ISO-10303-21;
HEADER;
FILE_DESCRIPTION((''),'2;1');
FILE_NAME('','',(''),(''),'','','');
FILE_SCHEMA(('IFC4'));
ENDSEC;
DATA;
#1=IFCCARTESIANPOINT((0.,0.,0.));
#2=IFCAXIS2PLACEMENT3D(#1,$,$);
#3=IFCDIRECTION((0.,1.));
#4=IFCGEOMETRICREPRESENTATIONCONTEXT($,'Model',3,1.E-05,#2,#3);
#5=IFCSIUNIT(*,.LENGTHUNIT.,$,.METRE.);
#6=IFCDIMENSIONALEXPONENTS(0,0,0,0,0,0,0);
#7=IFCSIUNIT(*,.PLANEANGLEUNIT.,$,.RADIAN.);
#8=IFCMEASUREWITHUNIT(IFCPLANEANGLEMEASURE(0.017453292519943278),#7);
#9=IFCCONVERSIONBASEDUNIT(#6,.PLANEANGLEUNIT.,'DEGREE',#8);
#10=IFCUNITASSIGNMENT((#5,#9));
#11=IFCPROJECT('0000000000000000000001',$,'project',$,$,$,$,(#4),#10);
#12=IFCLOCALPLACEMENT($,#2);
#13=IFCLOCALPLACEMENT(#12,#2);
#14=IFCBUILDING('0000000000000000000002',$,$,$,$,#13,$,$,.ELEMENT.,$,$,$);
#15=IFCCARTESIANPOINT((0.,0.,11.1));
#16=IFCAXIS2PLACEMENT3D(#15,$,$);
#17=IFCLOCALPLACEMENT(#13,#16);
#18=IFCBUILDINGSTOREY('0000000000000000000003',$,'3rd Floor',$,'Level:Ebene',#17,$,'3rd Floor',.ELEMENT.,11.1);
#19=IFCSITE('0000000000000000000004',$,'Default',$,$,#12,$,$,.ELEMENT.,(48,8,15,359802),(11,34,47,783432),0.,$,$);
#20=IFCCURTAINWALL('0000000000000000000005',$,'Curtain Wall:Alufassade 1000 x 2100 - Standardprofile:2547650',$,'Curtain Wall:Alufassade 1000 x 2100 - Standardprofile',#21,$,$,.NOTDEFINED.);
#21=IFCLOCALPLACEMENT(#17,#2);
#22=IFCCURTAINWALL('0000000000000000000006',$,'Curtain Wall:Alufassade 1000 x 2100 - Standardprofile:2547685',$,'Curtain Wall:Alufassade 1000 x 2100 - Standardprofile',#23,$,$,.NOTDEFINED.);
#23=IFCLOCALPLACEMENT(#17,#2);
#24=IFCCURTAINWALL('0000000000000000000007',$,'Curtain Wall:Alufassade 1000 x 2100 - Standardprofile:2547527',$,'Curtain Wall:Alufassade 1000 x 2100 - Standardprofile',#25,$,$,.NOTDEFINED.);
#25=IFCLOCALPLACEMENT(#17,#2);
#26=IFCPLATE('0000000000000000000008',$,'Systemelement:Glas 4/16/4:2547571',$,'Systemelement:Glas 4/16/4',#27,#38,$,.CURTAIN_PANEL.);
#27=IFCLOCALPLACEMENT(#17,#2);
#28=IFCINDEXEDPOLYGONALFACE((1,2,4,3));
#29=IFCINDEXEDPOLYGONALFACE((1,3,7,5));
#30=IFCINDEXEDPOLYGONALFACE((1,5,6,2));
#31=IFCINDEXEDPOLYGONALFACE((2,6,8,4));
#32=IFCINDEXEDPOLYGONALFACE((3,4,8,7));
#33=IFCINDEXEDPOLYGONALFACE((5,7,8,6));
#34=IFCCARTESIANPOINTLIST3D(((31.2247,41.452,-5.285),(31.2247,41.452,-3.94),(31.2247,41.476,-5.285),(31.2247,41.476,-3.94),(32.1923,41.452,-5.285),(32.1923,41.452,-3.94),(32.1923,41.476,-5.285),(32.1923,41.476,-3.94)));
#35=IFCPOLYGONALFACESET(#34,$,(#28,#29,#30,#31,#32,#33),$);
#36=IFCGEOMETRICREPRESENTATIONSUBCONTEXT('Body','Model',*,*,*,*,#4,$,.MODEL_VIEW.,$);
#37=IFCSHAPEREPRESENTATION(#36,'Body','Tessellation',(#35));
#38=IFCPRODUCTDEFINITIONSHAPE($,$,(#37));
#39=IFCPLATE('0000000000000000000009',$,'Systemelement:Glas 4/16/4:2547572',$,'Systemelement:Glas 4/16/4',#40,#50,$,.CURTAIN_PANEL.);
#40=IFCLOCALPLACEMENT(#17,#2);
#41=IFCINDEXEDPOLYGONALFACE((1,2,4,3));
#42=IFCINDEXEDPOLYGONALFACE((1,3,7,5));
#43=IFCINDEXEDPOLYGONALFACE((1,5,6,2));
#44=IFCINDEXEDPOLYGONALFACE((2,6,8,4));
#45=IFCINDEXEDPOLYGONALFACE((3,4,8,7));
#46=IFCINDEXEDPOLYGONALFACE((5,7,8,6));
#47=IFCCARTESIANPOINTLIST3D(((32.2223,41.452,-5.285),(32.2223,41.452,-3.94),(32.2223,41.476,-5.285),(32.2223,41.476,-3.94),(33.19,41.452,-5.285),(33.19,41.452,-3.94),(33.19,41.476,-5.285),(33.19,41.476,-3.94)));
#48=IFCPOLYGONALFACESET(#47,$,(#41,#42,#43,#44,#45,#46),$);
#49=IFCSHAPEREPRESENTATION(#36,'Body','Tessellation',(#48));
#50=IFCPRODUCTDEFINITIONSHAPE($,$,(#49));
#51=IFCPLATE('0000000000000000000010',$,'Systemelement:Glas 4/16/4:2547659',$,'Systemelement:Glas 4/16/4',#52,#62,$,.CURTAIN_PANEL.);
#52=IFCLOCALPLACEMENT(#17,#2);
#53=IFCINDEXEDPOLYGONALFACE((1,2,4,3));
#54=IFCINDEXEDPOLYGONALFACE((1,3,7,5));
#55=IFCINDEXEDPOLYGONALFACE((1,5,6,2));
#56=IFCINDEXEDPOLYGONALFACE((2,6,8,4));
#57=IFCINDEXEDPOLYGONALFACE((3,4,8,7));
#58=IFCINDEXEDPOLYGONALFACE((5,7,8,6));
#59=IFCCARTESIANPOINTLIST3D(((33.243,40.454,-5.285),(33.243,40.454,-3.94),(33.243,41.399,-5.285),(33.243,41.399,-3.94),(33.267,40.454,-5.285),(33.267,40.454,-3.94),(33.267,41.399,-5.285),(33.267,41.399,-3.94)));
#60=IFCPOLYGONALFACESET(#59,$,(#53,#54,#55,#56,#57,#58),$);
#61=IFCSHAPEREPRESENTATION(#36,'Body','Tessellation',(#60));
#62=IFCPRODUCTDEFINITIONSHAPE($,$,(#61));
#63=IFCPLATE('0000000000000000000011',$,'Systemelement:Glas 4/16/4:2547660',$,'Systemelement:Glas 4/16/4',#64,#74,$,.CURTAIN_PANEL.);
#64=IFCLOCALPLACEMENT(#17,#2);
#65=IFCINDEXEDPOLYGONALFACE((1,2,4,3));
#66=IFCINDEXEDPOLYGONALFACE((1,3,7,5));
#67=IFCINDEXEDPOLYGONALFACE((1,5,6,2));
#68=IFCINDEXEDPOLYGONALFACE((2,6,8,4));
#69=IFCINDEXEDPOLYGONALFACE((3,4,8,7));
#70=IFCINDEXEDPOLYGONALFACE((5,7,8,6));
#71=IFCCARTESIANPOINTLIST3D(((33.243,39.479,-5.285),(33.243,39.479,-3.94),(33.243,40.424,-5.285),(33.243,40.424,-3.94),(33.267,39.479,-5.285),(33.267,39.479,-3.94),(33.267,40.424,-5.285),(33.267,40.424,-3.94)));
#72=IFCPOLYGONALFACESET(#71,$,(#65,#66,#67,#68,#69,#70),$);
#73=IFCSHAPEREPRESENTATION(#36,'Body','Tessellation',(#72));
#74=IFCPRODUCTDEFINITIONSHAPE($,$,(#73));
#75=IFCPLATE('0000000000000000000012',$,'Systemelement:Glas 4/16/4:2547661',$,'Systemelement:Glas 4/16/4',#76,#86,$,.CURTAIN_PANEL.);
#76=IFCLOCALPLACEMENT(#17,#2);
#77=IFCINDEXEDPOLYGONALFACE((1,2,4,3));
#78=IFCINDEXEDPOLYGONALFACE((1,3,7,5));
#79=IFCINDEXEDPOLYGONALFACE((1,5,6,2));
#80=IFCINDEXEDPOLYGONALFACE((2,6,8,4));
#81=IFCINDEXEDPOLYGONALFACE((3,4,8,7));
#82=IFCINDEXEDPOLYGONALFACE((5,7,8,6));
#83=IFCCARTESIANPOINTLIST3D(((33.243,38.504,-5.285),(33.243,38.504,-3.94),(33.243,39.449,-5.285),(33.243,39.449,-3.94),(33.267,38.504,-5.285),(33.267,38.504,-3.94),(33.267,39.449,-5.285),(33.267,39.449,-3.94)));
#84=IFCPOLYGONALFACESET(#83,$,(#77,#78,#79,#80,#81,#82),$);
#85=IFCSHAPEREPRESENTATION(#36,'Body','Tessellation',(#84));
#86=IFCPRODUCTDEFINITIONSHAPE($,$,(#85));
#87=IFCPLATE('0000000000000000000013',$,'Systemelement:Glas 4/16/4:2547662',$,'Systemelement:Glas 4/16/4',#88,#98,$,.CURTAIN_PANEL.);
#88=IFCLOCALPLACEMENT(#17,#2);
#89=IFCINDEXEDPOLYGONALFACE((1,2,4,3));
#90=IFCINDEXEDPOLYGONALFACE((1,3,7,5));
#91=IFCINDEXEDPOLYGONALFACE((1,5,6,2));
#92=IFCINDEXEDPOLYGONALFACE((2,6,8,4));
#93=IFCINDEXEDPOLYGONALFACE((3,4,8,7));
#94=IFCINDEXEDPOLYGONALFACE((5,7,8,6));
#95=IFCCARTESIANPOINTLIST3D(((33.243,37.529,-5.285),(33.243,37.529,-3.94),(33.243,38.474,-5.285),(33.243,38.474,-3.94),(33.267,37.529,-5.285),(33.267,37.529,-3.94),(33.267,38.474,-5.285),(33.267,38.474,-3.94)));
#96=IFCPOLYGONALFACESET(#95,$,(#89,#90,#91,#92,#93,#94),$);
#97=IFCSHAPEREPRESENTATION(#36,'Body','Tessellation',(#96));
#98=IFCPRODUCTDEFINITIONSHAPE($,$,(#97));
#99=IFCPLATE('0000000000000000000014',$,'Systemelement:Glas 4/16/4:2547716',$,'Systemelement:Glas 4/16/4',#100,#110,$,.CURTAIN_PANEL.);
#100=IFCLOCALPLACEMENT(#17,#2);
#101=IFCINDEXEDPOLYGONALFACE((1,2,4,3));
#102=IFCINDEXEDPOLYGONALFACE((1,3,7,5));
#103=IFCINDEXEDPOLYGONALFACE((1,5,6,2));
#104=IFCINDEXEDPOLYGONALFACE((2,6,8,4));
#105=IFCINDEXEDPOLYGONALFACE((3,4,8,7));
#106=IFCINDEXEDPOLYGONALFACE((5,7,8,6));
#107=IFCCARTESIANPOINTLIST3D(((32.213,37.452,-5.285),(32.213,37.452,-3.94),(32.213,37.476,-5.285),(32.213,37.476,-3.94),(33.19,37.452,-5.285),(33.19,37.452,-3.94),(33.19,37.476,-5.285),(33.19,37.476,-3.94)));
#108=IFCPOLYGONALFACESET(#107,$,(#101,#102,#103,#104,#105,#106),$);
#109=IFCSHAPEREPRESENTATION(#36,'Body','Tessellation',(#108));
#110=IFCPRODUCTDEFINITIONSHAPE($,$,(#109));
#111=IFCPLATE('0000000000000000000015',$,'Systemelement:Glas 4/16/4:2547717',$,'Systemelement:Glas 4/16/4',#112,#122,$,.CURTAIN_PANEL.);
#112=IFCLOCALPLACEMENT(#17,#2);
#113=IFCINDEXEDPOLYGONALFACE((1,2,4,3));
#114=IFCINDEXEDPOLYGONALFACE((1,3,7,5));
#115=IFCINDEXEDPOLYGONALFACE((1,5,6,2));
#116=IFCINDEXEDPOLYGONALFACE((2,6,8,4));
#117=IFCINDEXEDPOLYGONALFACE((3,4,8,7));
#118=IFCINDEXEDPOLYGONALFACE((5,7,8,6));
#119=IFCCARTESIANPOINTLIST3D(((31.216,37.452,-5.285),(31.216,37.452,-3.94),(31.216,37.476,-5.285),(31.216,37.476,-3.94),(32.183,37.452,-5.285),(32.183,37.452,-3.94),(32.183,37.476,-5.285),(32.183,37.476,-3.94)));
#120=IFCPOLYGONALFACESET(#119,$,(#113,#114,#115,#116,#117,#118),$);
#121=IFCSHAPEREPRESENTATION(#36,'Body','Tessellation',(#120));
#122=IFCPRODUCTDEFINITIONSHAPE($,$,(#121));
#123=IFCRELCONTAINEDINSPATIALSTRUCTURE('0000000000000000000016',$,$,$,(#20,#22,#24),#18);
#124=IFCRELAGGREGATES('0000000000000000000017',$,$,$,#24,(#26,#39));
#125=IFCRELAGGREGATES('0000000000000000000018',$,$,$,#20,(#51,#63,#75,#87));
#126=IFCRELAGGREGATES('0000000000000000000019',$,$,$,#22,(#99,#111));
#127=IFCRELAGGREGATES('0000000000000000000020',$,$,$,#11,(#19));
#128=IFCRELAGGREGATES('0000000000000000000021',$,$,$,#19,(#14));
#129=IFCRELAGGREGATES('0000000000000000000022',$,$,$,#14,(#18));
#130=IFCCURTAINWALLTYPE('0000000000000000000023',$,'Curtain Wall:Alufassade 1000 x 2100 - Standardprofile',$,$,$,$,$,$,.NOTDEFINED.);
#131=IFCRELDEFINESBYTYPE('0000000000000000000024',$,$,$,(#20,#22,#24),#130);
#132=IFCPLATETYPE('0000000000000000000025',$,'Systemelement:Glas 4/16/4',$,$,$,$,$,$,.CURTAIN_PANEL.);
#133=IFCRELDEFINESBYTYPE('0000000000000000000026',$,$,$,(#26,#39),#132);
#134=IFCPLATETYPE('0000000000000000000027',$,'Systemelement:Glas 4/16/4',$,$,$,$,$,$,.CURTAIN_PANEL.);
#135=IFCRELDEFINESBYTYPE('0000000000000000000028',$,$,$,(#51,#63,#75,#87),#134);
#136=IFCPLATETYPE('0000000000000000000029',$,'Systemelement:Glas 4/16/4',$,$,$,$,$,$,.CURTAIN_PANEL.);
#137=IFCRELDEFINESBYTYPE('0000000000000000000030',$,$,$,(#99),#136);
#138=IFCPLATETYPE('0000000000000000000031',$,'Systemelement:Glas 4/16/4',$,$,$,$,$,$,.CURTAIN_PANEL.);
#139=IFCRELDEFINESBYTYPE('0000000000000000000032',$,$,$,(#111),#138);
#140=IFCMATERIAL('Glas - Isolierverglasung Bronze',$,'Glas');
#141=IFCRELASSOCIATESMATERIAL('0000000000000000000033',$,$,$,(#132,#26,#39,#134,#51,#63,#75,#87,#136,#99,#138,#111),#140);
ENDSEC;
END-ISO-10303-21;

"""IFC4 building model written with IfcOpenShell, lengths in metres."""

from ifc_helpers import new_model, entity, si_unit, converted_unit, direction, frame, origin, place, context, subcontext, project, spatial, indexed_curve, outline, extrude, source, transform, mapped, material, type_object, type_shapes, element, aggregate, save


model = new_model("IFC4")

# Units and contexts
model_context = context("Model", 3, precision=1e-05, world=origin(), true_north=direction((0.0, 1.0)))
body_context = subcontext(model_context, "Body", "Model", "MODEL_VIEW")
ifc_project = project(units=[si_unit("LENGTHUNIT", "METRE"), converted_unit("PLANEANGLEUNIT", "DEGREE", entity("IfcPlaneAngleMeasure", 0.017453292519943278), si_unit("PLANEANGLEUNIT", "RADIAN"), dimensions=[0, 0, 0, 0, 0, 0, 0])], contexts=[model_context])

# Site, building, storey
site_placement = place(None, origin())
site = spatial("IfcSite", under=ifc_project, at=site_placement, Name="Default", CompositionType="ELEMENT", RefLatitude=(48, 8, 15, 359802), RefLongitude=(11, 34, 47, 783432), RefElevation=0.0)
building_placement = place(site_placement, origin())
building = spatial("IfcBuilding", under=site, at=building_placement, CompositionType="ELEMENT")
storey_placement = place(building_placement, frame((0.0, 0.0, 11.1)))
storey = spatial("IfcBuildingStorey", under=building, at=storey_placement, Name="3rd Floor", ObjectType="Level:Ebene", LongName="3rd Floor", CompositionType="ELEMENT", Elevation=11.1)

# Curtain walls
curtain_wall_type = type_object("IfcCurtainWallType", Name="Curtain Wall:Alufassade 1000 x 2100 - Standardprofile", PredefinedType="NOTDEFINED")
curtain_wall_1_placement = place(storey_placement, frame((0.0, 0.0, -11.1)))
curtain_wall_1 = element("IfcCurtainWall", 1, at=curtain_wall_1_placement, inside=storey, type_object=curtain_wall_type, Name="Curtain Wall:Alufassade 1000 x 2100 - Standardprofile:2547650", ObjectType="Curtain Wall:Alufassade 1000 x 2100 - Standardprofile", PredefinedType="NOTDEFINED")
curtain_wall_2_placement = place(storey_placement, frame((0.0, 0.0, -11.1)))
curtain_wall_2 = element("IfcCurtainWall", 2, at=curtain_wall_2_placement, inside=storey, type_object=curtain_wall_type, Name="Curtain Wall:Alufassade 1000 x 2100 - Standardprofile:2547685", ObjectType="Curtain Wall:Alufassade 1000 x 2100 - Standardprofile", PredefinedType="NOTDEFINED")

# Curtain wall
curtain_wall_3_placement = place(storey_placement, frame((0.0, 0.0, -11.1)))
curtain_wall_3 = element("IfcCurtainWall", 3, at=curtain_wall_3_placement, inside=storey, type_object=curtain_wall_type, Name="Curtain Wall:Alufassade 1000 x 2100 - Standardprofile:2547527", ObjectType="Curtain Wall:Alufassade 1000 x 2100 - Standardprofile", PredefinedType="NOTDEFINED")

# Plates
ifc_material_1 = material(Name="Glas - Isolierverglasung Bronze", Category="Glas")
plate_type_1 = type_object("IfcPlateType", Name="Systemelement:Glas 4/16/4", PredefinedType="CURTAIN_PANEL", material=ifc_material_1)
shared_shape_1 = source(origin(), body_context, "Body", "SweptSolid", [
    extrude(outline(indexed_curve([(-0.012, -0.4838), (0.012, -0.4838), (0.012, 0.4838), (-0.012, 0.4838), (-0.012, -0.4838)], self_intersect=False)), frame((0.0, 0.0, 0.0), z_axis=(0.0, 0.0, 1.0), x_axis=(0.0, 1.0, 0.0)), (0.0, 0.0, 1.0), 1.345),
])
type_shapes(plate_type_1, [shared_shape_1])
plate_1_placement = place(curtain_wall_3_placement, frame((31.7085, 41.464, 5.815)))
plate_1 = element("IfcPlate", 4, at=plate_1_placement, type_object=plate_type_1, material=ifc_material_1, Name="Systemelement:Glas 4/16/4:2547571", ObjectType="Systemelement:Glas 4/16/4", PredefinedType="CURTAIN_PANEL", context=body_context, shape_type="MappedRepresentation", body=[
    mapped(shared_shape_1, transform((0.0, 0.0, 0.0), scale=1.0)),
])
plate_2_placement = place(curtain_wall_3_placement, frame((32.7062, 41.464, 5.815)))
plate_2 = element("IfcPlate", 5, at=plate_2_placement, type_object=plate_type_1, material=ifc_material_1, Name="Systemelement:Glas 4/16/4:2547572", ObjectType="Systemelement:Glas 4/16/4", PredefinedType="CURTAIN_PANEL", context=body_context, shape_type="MappedRepresentation", body=[
    mapped(shared_shape_1, transform((0.0, 0.0, 0.0), scale=1.0)),
])
aggregate(curtain_wall_3, [plate_1, plate_2])
plate_type_2 = type_object("IfcPlateType", Name="Systemelement:Glas 4/16/4", PredefinedType="CURTAIN_PANEL", material=ifc_material_1)
shared_shape_2 = source(origin(), body_context, "Body", "SweptSolid", [
    extrude(outline(indexed_curve([(-0.012, -0.4725), (0.012, -0.4725), (0.012, 0.4725), (-0.012, 0.4725), (-0.012, -0.4725)], self_intersect=False)), frame((0.0, 0.0, 0.0), z_axis=(0.0, 0.0, 1.0), x_axis=(0.0, 1.0, 0.0)), (0.0, 0.0, 1.0), 1.345),
])
type_shapes(plate_type_2, [shared_shape_2])
plate_3_placement = place(curtain_wall_1_placement, frame((33.255, 40.9265, 5.815), z_axis=(0.0, 0.0, 1.0), x_axis=(0.0, -1.0, 0.0)))
plate_3 = element("IfcPlate", 6, at=plate_3_placement, type_object=plate_type_2, material=ifc_material_1, Name="Systemelement:Glas 4/16/4:2547659", ObjectType="Systemelement:Glas 4/16/4", PredefinedType="CURTAIN_PANEL", context=body_context, shape_type="MappedRepresentation", body=[
    mapped(shared_shape_2, transform((0.0, 0.0, 0.0), scale=1.0)),
])
plate_4_placement = place(curtain_wall_1_placement, frame((33.255, 39.9515, 5.815), z_axis=(0.0, 0.0, 1.0), x_axis=(0.0, -1.0, 0.0)))
plate_4 = element("IfcPlate", 7, at=plate_4_placement, type_object=plate_type_2, material=ifc_material_1, Name="Systemelement:Glas 4/16/4:2547660", ObjectType="Systemelement:Glas 4/16/4", PredefinedType="CURTAIN_PANEL", context=body_context, shape_type="MappedRepresentation", body=[
    mapped(shared_shape_2, transform((0.0, 0.0, 0.0), scale=1.0)),
])
plate_5_placement = place(curtain_wall_1_placement, frame((33.255, 38.9765, 5.815), z_axis=(0.0, 0.0, 1.0), x_axis=(0.0, -1.0, 0.0)))
plate_5 = element("IfcPlate", 8, at=plate_5_placement, type_object=plate_type_2, material=ifc_material_1, Name="Systemelement:Glas 4/16/4:2547661", ObjectType="Systemelement:Glas 4/16/4", PredefinedType="CURTAIN_PANEL", context=body_context, shape_type="MappedRepresentation", body=[
    mapped(shared_shape_2, transform((0.0, 0.0, 0.0), scale=1.0)),
])
plate_6_placement = place(curtain_wall_1_placement, frame((33.255, 38.0015, 5.815), z_axis=(0.0, 0.0, 1.0), x_axis=(0.0, -1.0, 0.0)))
plate_6 = element("IfcPlate", 9, at=plate_6_placement, type_object=plate_type_2, material=ifc_material_1, Name="Systemelement:Glas 4/16/4:2547662", ObjectType="Systemelement:Glas 4/16/4", PredefinedType="CURTAIN_PANEL", context=body_context, shape_type="MappedRepresentation", body=[
    mapped(shared_shape_2, transform((0.0, 0.0, 0.0), scale=1.0)),
])
aggregate(curtain_wall_1, [plate_3, plate_4, plate_5, plate_6])
plate_type_3 = type_object("IfcPlateType", Name="Systemelement:Glas 4/16/4", PredefinedType="CURTAIN_PANEL", material=ifc_material_1)
shared_shape_3 = source(origin(), body_context, "Body", "SweptSolid", [
    extrude(outline(indexed_curve([(-0.012, -0.4885), (0.012, -0.4885), (0.012, 0.4885), (-0.012, 0.4885), (-0.012, -0.4885)], self_intersect=False)), frame((0.0, 0.0, 0.0), z_axis=(0.0, 0.0, 1.0), x_axis=(0.0, 1.0, 0.0)), (0.0, 0.0, 1.0), 1.345),
])
type_shapes(plate_type_3, [shared_shape_3])
plate_7_placement = place(curtain_wall_2_placement, frame((32.7015, 37.464, 5.815), z_axis=(0.0, 0.0, 1.0), x_axis=(-1.0, 0.0, 0.0)))
plate_7 = element("IfcPlate", 10, at=plate_7_placement, type_object=plate_type_3, material=ifc_material_1, Name="Systemelement:Glas 4/16/4:2547716", ObjectType="Systemelement:Glas 4/16/4", PredefinedType="CURTAIN_PANEL", context=body_context, shape_type="MappedRepresentation", body=[
    mapped(shared_shape_3, transform((0.0, 0.0, 0.0), scale=1.0)),
])
plate_type_4 = type_object("IfcPlateType", Name="Systemelement:Glas 4/16/4", PredefinedType="CURTAIN_PANEL", material=ifc_material_1)
shared_shape_4 = source(origin(), body_context, "Body", "SweptSolid", [
    extrude(outline(indexed_curve([(-0.012, -0.4835), (0.012, -0.4835), (0.012, 0.4835), (-0.012, 0.4835), (-0.012, -0.4835)], self_intersect=False)), frame((0.0, 0.0, 0.0), z_axis=(0.0, 0.0, 1.0), x_axis=(0.0, 1.0, 0.0)), (0.0, 0.0, 1.0), 1.345),
])
type_shapes(plate_type_4, [shared_shape_4])
plate_8_placement = place(curtain_wall_2_placement, frame((31.6995, 37.464, 5.815), z_axis=(0.0, 0.0, 1.0), x_axis=(-1.0, 0.0, 0.0)))
plate_8 = element("IfcPlate", 11, at=plate_8_placement, type_object=plate_type_4, material=ifc_material_1, Name="Systemelement:Glas 4/16/4:2547717", ObjectType="Systemelement:Glas 4/16/4", PredefinedType="CURTAIN_PANEL", context=body_context, shape_type="MappedRepresentation", body=[
    mapped(shared_shape_4, transform((0.0, 0.0, 0.0), scale=1.0)),
])
aggregate(curtain_wall_2, [plate_7, plate_8])

save(model, "model.ifc")
